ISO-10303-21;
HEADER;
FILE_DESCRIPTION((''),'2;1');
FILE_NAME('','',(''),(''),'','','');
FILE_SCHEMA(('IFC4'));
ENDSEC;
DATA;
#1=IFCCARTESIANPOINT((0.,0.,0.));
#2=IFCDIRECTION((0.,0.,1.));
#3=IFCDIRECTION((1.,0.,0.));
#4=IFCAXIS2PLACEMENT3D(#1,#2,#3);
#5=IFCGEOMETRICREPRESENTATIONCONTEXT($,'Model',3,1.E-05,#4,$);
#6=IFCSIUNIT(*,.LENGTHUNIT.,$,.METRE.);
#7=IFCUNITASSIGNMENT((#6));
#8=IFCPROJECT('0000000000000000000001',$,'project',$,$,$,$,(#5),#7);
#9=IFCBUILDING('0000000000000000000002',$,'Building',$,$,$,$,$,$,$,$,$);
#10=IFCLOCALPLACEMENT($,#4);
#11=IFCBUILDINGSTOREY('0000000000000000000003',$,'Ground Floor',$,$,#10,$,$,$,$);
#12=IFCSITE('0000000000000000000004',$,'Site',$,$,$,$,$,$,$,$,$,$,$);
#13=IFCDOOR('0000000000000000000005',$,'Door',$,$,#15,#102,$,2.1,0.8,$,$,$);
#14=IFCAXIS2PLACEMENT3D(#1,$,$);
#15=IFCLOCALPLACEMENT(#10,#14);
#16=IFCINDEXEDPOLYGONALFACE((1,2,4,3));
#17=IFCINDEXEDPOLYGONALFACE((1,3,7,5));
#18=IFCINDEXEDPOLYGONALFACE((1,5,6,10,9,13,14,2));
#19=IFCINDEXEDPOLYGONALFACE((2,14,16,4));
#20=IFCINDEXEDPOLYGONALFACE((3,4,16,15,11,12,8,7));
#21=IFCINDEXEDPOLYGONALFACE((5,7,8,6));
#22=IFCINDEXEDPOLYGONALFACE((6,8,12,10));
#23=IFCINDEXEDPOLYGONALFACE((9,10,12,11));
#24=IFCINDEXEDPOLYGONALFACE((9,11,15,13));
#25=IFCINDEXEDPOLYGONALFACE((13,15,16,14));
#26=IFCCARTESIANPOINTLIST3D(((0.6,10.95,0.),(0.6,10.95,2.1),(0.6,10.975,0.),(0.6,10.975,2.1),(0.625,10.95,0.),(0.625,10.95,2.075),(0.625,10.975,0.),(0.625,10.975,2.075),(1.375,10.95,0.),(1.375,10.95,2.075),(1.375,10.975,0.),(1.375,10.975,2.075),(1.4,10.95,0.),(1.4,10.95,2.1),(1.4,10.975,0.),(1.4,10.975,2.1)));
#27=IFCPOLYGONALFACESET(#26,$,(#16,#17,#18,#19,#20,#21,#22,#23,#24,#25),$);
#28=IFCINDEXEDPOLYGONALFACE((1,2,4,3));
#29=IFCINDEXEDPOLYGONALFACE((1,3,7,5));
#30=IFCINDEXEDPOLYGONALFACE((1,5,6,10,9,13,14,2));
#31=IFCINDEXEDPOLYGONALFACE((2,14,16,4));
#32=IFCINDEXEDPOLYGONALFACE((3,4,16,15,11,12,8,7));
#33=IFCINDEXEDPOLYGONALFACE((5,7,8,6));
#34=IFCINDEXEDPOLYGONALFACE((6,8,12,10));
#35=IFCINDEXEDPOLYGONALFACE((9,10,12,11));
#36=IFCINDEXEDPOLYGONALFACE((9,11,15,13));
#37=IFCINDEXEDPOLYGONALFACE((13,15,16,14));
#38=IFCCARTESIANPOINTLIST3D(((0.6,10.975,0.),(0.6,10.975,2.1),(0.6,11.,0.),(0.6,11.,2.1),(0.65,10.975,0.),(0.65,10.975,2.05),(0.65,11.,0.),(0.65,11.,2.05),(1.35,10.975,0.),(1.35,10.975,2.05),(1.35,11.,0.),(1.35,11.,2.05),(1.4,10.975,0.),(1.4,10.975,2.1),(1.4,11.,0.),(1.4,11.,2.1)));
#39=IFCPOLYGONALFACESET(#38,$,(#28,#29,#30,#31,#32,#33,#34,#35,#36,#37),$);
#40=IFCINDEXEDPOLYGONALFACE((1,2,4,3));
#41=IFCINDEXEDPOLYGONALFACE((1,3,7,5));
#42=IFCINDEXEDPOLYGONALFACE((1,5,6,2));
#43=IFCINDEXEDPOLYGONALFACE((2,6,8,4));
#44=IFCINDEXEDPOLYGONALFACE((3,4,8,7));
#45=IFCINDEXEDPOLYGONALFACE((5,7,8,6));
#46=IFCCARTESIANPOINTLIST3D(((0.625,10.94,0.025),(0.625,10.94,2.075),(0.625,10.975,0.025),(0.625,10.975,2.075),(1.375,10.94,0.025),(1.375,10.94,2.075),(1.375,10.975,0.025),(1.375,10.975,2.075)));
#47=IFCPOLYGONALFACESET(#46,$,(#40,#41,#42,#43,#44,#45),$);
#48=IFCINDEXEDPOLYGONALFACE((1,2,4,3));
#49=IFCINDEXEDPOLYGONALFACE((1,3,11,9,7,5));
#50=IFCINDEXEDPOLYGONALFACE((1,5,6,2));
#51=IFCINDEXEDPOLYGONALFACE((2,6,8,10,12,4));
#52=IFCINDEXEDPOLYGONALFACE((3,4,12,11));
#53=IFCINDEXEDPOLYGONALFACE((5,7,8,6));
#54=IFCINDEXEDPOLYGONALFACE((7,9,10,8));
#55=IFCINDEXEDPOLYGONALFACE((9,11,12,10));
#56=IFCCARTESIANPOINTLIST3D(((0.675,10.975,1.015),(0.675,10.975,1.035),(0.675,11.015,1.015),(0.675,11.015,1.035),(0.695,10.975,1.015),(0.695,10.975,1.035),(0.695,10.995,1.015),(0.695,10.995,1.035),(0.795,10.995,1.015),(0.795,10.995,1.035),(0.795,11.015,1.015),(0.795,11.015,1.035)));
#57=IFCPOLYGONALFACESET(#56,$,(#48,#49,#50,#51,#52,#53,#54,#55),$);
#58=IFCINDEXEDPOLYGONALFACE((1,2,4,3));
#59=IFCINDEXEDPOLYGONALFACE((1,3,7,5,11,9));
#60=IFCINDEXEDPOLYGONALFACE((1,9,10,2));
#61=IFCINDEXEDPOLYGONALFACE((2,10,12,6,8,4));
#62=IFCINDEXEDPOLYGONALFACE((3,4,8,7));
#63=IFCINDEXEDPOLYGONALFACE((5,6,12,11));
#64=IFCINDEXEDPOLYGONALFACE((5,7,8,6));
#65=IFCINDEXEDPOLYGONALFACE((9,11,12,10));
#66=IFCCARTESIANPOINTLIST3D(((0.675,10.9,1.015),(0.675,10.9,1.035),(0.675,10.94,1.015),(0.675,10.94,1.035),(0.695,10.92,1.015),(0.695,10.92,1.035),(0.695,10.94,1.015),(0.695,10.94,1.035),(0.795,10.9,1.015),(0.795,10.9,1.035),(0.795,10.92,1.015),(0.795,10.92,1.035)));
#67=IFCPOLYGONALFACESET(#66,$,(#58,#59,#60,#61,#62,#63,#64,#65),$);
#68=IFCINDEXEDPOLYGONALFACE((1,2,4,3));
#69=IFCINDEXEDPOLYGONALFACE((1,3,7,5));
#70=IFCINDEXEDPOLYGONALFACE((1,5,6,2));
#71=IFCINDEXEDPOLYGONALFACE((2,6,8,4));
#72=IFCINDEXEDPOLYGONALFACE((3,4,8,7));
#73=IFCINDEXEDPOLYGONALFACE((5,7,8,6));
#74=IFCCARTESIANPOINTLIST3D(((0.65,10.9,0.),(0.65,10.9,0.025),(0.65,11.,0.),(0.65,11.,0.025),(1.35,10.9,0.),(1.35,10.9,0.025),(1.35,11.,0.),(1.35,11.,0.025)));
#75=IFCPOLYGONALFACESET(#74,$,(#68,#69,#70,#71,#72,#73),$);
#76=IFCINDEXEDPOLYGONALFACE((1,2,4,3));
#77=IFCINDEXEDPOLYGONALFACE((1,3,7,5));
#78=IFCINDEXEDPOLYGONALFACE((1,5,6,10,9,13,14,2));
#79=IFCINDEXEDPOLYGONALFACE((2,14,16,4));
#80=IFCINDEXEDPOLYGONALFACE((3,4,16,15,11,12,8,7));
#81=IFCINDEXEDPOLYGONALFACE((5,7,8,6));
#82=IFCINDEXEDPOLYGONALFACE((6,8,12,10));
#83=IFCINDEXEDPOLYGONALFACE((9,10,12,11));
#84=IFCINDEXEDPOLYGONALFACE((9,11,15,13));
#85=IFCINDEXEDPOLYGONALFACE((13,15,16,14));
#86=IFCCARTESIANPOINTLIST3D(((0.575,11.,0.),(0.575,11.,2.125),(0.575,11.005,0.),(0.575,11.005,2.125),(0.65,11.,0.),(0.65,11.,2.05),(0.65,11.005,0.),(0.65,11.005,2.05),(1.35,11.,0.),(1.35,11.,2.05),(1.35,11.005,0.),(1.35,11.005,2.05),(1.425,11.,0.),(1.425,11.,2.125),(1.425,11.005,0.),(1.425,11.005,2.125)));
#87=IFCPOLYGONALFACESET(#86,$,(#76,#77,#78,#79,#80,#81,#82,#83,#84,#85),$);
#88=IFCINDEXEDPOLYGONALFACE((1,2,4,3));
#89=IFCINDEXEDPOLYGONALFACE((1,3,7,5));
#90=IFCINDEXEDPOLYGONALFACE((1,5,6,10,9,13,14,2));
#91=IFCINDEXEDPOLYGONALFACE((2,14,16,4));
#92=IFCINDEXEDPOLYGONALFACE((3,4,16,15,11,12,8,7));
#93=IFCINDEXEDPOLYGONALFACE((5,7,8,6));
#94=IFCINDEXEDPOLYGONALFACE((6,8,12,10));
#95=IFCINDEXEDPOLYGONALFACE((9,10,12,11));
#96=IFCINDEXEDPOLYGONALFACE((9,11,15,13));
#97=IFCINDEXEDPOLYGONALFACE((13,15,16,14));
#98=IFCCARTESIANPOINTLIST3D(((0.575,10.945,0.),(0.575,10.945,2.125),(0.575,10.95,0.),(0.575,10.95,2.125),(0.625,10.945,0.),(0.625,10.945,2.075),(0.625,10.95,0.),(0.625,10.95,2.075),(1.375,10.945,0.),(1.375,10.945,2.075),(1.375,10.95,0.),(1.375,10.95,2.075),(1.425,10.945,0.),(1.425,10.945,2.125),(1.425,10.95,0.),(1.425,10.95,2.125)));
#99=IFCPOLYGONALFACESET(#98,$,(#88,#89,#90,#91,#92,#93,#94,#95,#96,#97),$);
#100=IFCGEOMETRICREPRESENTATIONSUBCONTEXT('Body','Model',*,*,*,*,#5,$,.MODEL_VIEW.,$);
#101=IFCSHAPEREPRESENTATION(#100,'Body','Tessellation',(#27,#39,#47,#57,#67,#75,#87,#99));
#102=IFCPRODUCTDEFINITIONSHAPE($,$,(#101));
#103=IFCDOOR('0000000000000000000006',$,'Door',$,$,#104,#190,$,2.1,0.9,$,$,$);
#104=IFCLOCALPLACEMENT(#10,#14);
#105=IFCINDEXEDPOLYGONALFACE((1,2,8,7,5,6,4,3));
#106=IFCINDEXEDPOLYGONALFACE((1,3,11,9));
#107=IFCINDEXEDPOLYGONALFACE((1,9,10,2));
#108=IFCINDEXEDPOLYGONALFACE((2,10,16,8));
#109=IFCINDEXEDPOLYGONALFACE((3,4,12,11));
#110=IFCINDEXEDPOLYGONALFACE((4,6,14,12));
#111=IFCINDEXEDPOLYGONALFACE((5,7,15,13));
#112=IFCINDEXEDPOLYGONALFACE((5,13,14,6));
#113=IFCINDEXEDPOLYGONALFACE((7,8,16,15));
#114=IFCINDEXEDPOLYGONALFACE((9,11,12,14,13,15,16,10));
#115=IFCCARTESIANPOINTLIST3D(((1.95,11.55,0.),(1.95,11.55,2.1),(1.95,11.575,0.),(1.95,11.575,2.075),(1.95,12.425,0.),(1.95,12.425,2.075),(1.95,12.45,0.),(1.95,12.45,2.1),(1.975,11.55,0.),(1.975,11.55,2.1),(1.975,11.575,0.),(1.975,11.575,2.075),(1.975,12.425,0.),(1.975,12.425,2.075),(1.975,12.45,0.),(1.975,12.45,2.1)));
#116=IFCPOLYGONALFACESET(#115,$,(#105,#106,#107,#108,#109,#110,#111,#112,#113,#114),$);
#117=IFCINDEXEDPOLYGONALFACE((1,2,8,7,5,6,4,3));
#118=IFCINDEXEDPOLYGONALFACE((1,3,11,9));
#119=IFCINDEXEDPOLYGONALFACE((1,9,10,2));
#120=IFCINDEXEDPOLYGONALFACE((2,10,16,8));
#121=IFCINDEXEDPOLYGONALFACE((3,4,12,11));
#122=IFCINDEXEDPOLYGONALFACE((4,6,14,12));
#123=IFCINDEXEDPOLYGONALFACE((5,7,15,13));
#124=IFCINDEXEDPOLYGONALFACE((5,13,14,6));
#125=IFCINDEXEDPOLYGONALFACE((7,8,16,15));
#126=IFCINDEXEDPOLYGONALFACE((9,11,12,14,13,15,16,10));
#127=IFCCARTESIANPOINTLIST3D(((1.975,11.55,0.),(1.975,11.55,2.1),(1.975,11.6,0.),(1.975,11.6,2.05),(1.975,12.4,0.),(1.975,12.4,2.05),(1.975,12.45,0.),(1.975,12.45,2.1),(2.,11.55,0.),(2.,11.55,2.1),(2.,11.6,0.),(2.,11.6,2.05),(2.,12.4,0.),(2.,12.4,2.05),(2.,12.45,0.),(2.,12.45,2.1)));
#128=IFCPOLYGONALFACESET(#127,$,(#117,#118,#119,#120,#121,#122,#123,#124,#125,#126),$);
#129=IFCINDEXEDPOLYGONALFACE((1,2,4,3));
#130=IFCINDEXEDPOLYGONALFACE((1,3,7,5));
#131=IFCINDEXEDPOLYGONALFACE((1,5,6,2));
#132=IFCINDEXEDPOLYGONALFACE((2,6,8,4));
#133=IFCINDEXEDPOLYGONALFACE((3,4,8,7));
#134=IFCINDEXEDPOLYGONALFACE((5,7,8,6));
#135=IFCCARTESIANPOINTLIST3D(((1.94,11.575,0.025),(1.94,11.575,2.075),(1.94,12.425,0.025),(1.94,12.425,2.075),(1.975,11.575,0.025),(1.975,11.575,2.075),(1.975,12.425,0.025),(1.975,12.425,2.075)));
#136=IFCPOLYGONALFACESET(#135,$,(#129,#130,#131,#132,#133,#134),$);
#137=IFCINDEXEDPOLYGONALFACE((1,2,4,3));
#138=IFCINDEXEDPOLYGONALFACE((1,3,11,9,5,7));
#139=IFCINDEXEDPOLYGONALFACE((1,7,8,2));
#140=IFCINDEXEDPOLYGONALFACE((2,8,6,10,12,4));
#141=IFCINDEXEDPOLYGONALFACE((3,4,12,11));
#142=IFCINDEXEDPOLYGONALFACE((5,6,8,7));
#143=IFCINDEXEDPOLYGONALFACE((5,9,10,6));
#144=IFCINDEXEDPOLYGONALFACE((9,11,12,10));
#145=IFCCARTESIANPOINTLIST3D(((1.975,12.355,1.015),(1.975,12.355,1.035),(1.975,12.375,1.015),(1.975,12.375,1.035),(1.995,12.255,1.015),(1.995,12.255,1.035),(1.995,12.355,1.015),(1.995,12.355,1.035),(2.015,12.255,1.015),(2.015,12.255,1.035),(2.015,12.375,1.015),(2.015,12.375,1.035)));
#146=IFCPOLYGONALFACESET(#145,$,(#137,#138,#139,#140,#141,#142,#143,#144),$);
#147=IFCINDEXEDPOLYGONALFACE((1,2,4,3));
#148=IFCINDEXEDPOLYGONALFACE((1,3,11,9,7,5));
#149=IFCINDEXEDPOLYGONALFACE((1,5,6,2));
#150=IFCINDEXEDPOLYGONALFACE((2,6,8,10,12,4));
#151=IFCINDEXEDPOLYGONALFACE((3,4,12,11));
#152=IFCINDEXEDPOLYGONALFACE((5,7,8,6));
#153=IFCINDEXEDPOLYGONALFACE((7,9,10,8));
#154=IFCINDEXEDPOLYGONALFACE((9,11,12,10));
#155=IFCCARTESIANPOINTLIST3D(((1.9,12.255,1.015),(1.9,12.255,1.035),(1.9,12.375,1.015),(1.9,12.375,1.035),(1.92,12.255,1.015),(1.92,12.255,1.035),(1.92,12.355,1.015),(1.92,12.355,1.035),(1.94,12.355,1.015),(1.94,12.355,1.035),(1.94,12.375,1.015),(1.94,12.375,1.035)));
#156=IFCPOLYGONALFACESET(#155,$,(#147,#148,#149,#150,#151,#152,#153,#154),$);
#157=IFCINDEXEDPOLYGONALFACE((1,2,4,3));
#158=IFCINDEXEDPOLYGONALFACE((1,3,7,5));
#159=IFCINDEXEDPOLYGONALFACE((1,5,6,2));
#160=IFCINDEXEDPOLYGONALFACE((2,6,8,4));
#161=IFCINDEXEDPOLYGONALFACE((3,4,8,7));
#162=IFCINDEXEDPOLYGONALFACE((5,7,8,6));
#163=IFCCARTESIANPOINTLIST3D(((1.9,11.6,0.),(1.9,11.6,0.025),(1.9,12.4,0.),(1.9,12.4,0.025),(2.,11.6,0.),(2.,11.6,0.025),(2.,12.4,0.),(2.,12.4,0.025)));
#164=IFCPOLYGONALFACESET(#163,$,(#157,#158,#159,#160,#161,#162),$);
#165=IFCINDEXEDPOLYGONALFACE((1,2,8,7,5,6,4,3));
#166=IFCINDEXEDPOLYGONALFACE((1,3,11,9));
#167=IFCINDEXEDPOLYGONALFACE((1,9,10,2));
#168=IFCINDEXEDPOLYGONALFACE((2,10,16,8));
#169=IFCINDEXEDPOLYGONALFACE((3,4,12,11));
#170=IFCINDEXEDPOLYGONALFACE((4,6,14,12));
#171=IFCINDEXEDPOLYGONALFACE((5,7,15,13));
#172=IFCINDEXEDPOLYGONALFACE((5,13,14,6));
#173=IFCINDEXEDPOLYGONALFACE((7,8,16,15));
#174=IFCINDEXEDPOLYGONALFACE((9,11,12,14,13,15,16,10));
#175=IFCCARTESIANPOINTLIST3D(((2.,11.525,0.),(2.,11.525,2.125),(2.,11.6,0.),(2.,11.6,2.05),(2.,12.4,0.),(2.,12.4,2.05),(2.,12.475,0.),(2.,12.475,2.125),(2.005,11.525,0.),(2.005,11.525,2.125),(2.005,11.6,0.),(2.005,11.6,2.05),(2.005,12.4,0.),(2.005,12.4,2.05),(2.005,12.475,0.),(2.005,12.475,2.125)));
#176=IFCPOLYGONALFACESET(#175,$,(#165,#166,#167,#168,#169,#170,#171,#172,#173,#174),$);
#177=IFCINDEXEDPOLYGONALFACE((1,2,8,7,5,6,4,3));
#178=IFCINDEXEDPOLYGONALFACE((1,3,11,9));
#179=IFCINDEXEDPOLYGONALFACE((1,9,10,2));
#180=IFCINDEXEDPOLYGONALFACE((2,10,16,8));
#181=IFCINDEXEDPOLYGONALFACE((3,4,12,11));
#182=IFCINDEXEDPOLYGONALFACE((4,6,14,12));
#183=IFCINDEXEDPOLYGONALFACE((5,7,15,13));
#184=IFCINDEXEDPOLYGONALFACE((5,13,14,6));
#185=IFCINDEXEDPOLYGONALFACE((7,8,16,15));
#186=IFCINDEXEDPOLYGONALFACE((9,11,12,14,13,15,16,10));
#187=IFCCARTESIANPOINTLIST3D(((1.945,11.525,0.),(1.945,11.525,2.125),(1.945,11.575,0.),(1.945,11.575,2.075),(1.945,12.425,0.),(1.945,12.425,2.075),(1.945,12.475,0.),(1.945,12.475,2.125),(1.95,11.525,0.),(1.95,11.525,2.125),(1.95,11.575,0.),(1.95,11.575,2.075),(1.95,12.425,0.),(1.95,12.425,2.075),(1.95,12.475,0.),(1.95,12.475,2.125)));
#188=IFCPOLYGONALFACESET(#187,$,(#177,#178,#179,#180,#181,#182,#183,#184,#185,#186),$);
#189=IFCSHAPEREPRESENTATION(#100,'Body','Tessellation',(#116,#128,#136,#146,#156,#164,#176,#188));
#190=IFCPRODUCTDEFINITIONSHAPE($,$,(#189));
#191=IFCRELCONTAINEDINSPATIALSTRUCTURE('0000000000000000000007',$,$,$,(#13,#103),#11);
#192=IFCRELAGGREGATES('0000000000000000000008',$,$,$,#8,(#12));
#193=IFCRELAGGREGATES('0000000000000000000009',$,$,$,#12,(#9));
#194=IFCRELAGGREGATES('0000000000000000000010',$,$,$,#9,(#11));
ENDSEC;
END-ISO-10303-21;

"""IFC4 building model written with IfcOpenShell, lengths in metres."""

from ifc_helpers import new_model, si_unit, frame, origin_with_axes, place, context, subcontext, project, spatial, line, indexed_curve, outline, extrude, element, save


model = new_model("IFC4")

# Units and contexts
model_context = context("Model", 3, precision=1e-05, world=origin_with_axes())
body_context = subcontext(model_context, "Body", "Model", "MODEL_VIEW")
ifc_project = project(units=[si_unit("LENGTHUNIT", "METRE")], contexts=[model_context])

# Site, building, storey
site = spatial("IfcSite", under=ifc_project, Name="Site")
building = spatial("IfcBuilding", under=site, Name="Building")
storey_placement = place(None, origin_with_axes())
storey = spatial("IfcBuildingStorey", under=building, at=storey_placement, Name="Ground Floor")

# Doors
door_1_placement = place(storey_placement, frame((1.4, 11.0, 0.0), z_axis=(0.0, 0.0, 1.0), x_axis=(-1.0, 0.0, 0.0)))
element("IfcDoor", 1, at=door_1_placement, inside=storey, Name="Door", OverallHeight=2.1, OverallWidth=0.8, context=body_context, shape_type="SweptSolid", body=[
    extrude(outline(indexed_curve([(0.0, 0.0), (0.0, 2.1), (0.8, 2.1), (0.8, 0.0), (0.775, 0.0), (0.775, 2.075), (0.025, 2.075), (0.025, 0.0)], segments=[line(1, 2, 3, 4, 5, 6, 7, 8, 1)])), frame((0.0, 0.025, 0.0), z_axis=(0.0, -1.0, 0.0), x_axis=(1.0, 0.0, 0.0)), (0.0, 0.0, -1.0), 0.025),
    extrude(outline(indexed_curve([(0.0, 0.0), (0.0, 2.1), (0.8, 2.1), (0.8, 0.0), (0.75, 0.0), (0.75, 2.05), (0.05, 2.05), (0.05, 0.0)], segments=[line(1, 2, 3, 4, 5, 6, 7, 8, 1)])), frame((0.0, 0.0, 0.0), z_axis=(0.0, -1.0, 0.0), x_axis=(1.0, 0.0, 0.0)), (0.0, 0.0, -1.0), 0.025),
    extrude(outline(indexed_curve([(0.0, 0.0), (0.75, 0.0), (0.75, 0.035), (0.0, 0.035)], segments=[line(1, 2, 3, 4, 1)])), frame((0.025, 0.025, 0.025), z_axis=(0.0, 0.0, 1.0), x_axis=(1.0, 0.0, 0.0)), (0.0, 0.0, 1.0), 2.05),
    extrude(outline(indexed_curve([(0.0, 0.0), (0.0, -0.04), (-0.12, -0.04), (-0.12, -0.02), (-0.02, -0.02), (-0.02, 0.0)], segments=[line(1, 2, 3, 4, 5, 6, 1)])), frame((0.725, 0.025, 1.015), z_axis=(0.0, 0.0, 1.0), x_axis=(1.0, 0.0, 0.0)), (0.0, 0.0, 1.0), 0.02),
    extrude(outline(indexed_curve([(0.0, 0.0), (0.0, 0.04), (-0.12, 0.04), (-0.12, 0.02), (-0.02, 0.02), (-0.02, 0.0)], segments=[line(1, 2, 3, 4, 5, 6, 1)])), frame((0.725, 0.06, 1.015), z_axis=(0.0, 0.0, 1.0), x_axis=(1.0, 0.0, 0.0)), (0.0, 0.0, 1.0), 0.02),
    extrude(outline(indexed_curve([(0.0, 0.0), (0.7, 0.0), (0.7, 0.1), (0.0, 0.1)], segments=[line(1, 2, 3, 4, 1)])), frame((0.05, 0.0, 0.0), z_axis=(0.0, 0.0, 1.0), x_axis=(1.0, 0.0, 0.0)), (0.0, 0.0, 1.0), 0.025),
    extrude(outline(indexed_curve([(0.0, 0.0), (0.0, 2.125), (0.85, 2.125), (0.85, 0.0), (0.775, 0.0), (0.775, 2.05), (0.075, 2.05), (0.075, 0.0)], segments=[line(1, 2, 3, 4, 5, 6, 7, 8, 1)])), frame((-0.025, -0.005, 0.0), z_axis=(0.0, -1.0, 0.0), x_axis=(1.0, 0.0, 0.0)), (0.0, 0.0, -1.0), 0.005),
    extrude(outline(indexed_curve([(0.0, 0.0), (0.0, 2.125), (0.85, 2.125), (0.85, 0.0), (0.8, 0.0), (0.8, 2.075), (0.05, 2.075), (0.05, 0.0)], segments=[line(1, 2, 3, 4, 5, 6, 7, 8, 1)])), frame((-0.025, 0.05, 0.0), z_axis=(0.0, -1.0, 0.0), x_axis=(1.0, 0.0, 0.0)), (0.0, 0.0, -1.0), 0.005),
])
door_2_placement = place(storey_placement, frame((2.0, 11.55, 0.0), z_axis=(0.0, 0.0, 1.0), x_axis=(0.0, 1.0, 0.0)))
element("IfcDoor", 2, at=door_2_placement, inside=storey, Name="Door", OverallHeight=2.1, OverallWidth=0.9, context=body_context, shape_type="SweptSolid", body=[
    extrude(outline(indexed_curve([(0.0, 0.0), (0.0, 2.1), (0.9, 2.1), (0.9, 0.0), (0.875, 0.0), (0.875, 2.075), (0.025, 2.075), (0.025, 0.0)], segments=[line(1, 2, 3, 4, 5, 6, 7, 8, 1)])), frame((0.0, 0.025, 0.0), z_axis=(0.0, -1.0, 0.0), x_axis=(1.0, 0.0, 0.0)), (0.0, 0.0, -1.0), 0.025),
    extrude(outline(indexed_curve([(0.0, 0.0), (0.0, 2.1), (0.9, 2.1), (0.9, 0.0), (0.85, 0.0), (0.85, 2.05), (0.05, 2.05), (0.05, 0.0)], segments=[line(1, 2, 3, 4, 5, 6, 7, 8, 1)])), frame((0.0, 0.0, 0.0), z_axis=(0.0, -1.0, 0.0), x_axis=(1.0, 0.0, 0.0)), (0.0, 0.0, -1.0), 0.025),
    extrude(outline(indexed_curve([(0.0, 0.0), (0.85, 0.0), (0.85, 0.035), (0.0, 0.035)], segments=[line(1, 2, 3, 4, 1)])), frame((0.025, 0.025, 0.025), z_axis=(0.0, 0.0, 1.0), x_axis=(1.0, 0.0, 0.0)), (0.0, 0.0, 1.0), 2.05),
    extrude(outline(indexed_curve([(0.0, 0.0), (0.0, -0.04), (-0.12, -0.04), (-0.12, -0.02), (-0.02, -0.02), (-0.02, 0.0)], segments=[line(1, 2, 3, 4, 5, 6, 1)])), frame((0.825, 0.025, 1.015), z_axis=(0.0, 0.0, 1.0), x_axis=(1.0, 0.0, 0.0)), (0.0, 0.0, 1.0), 0.02),
    extrude(outline(indexed_curve([(0.0, 0.0), (0.0, 0.04), (-0.12, 0.04), (-0.12, 0.02), (-0.02, 0.02), (-0.02, 0.0)], segments=[line(1, 2, 3, 4, 5, 6, 1)])), frame((0.825, 0.06, 1.015), z_axis=(0.0, 0.0, 1.0), x_axis=(1.0, 0.0, 0.0)), (0.0, 0.0, 1.0), 0.02),
    extrude(outline(indexed_curve([(0.0, 0.0), (0.8, 0.0), (0.8, 0.1), (0.0, 0.1)], segments=[line(1, 2, 3, 4, 1)])), frame((0.05, 0.0, 0.0), z_axis=(0.0, 0.0, 1.0), x_axis=(1.0, 0.0, 0.0)), (0.0, 0.0, 1.0), 0.025),
    extrude(outline(indexed_curve([(0.0, 0.0), (0.0, 2.125), (0.95, 2.125), (0.95, 0.0), (0.875, 0.0), (0.875, 2.05), (0.075, 2.05), (0.075, 0.0)], segments=[line(1, 2, 3, 4, 5, 6, 7, 8, 1)])), frame((-0.025, -0.005, 0.0), z_axis=(0.0, -1.0, 0.0), x_axis=(1.0, 0.0, 0.0)), (0.0, 0.0, -1.0), 0.005),
    extrude(outline(indexed_curve([(0.0, 0.0), (0.0, 2.125), (0.95, 2.125), (0.95, 0.0), (0.9, 0.0), (0.9, 2.075), (0.05, 2.075), (0.05, 0.0)], segments=[line(1, 2, 3, 4, 5, 6, 7, 8, 1)])), frame((-0.025, 0.05, 0.0), z_axis=(0.0, -1.0, 0.0), x_axis=(1.0, 0.0, 0.0)), (0.0, 0.0, -1.0), 0.005),
])

save(model, "model.ifc")
